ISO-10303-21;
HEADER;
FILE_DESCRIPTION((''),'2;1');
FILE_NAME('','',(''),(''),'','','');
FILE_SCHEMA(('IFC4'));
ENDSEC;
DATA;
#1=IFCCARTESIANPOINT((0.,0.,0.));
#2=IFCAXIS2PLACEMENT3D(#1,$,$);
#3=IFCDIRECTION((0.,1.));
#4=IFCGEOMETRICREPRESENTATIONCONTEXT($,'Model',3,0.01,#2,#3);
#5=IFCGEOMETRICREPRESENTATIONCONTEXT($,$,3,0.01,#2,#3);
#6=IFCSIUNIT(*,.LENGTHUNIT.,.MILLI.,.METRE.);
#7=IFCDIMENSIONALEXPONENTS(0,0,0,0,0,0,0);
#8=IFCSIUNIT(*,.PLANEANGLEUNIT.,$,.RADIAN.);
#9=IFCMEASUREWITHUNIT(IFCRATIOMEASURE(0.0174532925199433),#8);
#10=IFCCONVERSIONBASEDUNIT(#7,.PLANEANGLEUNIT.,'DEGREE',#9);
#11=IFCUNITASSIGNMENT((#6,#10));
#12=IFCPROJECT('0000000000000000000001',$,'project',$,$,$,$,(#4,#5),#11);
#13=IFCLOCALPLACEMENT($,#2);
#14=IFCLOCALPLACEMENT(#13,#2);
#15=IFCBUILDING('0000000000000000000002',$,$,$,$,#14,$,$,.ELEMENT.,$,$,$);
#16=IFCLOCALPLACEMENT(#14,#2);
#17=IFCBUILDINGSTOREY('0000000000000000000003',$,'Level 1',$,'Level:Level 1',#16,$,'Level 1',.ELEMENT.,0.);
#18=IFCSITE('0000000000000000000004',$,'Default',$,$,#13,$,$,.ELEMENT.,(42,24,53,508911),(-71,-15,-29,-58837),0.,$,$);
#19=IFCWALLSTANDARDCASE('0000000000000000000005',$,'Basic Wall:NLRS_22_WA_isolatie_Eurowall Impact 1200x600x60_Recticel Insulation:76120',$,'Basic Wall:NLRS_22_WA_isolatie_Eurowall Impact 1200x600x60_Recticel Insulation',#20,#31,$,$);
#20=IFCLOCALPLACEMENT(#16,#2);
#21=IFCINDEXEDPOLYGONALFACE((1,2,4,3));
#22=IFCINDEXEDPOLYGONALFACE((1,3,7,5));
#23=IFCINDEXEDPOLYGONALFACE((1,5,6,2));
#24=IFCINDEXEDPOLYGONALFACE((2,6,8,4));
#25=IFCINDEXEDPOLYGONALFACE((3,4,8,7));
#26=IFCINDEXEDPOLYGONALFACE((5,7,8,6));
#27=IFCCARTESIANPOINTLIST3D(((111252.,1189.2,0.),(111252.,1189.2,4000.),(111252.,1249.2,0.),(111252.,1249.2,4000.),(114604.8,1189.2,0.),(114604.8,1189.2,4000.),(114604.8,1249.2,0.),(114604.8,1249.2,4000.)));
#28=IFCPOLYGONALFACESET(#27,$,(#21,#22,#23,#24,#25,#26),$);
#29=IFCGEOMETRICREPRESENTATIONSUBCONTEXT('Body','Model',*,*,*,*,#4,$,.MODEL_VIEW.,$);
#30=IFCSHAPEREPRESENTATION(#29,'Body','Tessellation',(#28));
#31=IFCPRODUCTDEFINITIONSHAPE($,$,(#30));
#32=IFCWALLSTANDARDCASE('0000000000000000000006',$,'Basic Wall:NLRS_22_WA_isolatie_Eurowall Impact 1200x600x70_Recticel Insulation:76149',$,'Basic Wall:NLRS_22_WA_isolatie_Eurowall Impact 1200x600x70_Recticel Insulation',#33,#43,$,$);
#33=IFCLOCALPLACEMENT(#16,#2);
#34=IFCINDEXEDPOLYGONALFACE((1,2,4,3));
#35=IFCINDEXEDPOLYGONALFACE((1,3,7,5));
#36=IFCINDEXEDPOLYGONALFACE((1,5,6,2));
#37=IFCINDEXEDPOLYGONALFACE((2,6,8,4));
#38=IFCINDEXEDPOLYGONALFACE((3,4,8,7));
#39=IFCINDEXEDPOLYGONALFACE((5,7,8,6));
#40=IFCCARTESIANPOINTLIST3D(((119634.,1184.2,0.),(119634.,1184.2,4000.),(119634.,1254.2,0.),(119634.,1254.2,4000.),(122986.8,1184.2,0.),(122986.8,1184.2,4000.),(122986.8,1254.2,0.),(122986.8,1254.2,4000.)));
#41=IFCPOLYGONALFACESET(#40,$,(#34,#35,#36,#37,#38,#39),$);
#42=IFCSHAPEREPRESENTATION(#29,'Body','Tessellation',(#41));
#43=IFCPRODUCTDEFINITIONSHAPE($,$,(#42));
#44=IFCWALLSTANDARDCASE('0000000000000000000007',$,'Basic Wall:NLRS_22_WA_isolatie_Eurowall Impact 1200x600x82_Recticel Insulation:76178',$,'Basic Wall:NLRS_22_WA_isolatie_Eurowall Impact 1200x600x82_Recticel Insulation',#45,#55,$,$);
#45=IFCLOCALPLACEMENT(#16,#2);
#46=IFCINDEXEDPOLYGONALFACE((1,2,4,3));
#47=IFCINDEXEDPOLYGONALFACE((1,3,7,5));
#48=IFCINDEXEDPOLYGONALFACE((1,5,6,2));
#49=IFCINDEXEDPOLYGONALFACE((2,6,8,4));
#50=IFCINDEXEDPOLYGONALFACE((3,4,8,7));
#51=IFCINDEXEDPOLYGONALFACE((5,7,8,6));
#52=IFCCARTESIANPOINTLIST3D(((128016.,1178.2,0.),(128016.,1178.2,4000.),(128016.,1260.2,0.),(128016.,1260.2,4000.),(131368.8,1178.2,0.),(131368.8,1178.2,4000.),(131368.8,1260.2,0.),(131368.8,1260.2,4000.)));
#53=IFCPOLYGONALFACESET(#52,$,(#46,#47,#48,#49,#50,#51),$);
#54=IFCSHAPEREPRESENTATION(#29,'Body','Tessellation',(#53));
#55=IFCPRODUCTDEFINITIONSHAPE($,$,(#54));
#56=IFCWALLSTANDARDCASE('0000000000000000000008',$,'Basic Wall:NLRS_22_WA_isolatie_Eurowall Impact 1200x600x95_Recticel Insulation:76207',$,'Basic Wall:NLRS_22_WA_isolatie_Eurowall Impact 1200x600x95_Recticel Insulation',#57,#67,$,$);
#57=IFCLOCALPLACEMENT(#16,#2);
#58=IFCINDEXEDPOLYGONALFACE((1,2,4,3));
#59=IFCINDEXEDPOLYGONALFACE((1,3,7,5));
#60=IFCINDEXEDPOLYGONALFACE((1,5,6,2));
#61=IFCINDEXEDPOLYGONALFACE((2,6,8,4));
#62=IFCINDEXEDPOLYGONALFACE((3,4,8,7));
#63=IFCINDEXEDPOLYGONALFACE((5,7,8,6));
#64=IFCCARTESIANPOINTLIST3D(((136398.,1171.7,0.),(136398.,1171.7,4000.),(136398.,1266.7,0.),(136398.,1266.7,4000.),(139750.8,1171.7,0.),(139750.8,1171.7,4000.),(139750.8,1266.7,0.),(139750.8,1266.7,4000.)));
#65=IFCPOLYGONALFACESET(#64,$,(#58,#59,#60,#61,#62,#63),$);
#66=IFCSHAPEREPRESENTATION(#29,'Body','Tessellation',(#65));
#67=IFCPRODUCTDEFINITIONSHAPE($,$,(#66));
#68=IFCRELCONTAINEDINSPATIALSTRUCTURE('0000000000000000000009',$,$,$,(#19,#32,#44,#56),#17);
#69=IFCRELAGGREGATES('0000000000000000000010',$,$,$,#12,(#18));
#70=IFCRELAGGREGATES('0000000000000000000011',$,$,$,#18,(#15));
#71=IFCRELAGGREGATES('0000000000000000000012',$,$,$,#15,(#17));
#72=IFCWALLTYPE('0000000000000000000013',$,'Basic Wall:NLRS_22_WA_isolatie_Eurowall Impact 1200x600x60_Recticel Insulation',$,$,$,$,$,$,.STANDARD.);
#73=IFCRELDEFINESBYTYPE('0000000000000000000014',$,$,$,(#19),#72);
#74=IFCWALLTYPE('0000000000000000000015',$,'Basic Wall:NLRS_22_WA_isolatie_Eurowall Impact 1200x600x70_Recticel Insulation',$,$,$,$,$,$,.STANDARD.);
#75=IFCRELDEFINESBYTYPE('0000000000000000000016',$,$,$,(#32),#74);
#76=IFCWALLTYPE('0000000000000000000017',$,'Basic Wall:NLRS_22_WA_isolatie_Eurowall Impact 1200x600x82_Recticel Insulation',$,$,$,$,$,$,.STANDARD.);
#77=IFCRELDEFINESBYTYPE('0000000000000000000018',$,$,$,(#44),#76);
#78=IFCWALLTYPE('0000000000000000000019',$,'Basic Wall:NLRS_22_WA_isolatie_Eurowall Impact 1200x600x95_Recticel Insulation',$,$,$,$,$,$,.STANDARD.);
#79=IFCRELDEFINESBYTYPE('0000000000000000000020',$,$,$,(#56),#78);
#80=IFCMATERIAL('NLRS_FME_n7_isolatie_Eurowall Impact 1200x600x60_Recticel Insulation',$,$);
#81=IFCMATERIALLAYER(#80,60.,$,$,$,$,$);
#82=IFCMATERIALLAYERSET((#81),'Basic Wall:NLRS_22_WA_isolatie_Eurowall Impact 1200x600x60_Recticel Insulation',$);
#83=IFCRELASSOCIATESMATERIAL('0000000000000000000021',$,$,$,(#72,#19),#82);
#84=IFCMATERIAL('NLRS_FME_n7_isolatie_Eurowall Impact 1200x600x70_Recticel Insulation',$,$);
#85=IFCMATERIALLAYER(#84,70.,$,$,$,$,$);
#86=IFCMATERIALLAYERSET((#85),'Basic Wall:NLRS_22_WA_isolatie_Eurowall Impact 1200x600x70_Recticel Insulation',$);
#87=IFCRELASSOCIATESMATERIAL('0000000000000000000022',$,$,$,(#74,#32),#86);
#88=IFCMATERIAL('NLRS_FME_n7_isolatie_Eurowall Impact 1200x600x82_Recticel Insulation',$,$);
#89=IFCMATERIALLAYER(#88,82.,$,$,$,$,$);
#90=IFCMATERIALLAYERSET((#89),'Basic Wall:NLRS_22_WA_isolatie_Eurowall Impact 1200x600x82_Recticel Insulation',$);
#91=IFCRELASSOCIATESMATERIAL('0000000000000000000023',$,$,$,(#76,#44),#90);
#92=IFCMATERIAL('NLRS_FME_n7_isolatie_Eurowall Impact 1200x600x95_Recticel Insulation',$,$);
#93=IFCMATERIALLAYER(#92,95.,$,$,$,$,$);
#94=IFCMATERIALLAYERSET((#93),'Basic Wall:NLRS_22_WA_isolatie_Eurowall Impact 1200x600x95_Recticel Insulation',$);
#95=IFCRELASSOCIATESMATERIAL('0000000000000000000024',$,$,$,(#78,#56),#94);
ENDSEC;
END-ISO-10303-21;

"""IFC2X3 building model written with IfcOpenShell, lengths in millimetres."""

from ifc_helpers import new_model, entity, si_unit, converted_unit, direction, frame, frame_2d, origin, place, context, subcontext, project, spatial, rectangle, extrude, material, layer, layer_set, layer_usage, type_object, element, save


model = new_model("IFC2X3")

# Units and contexts
model_context = context("Model", 3, precision=0.01, world=origin(), true_north=direction((0.0, 1.0)))
context_of_model = context(None, 3, precision=0.01, world=origin(), true_north=direction((0.0, 1.0)))
body_context = subcontext(model_context, "Body", "Model", "MODEL_VIEW")
ifc_project = project(units=[si_unit("LENGTHUNIT", "METRE", prefix="MILLI"), converted_unit("PLANEANGLEUNIT", "DEGREE", entity("IfcRatioMeasure", 0.0174532925199433), si_unit("PLANEANGLEUNIT", "RADIAN"), dimensions=[0, 0, 0, 0, 0, 0, 0])], contexts=[model_context, context_of_model])

# Site, building, storey
site_placement = place(None, origin())
site = spatial("IfcSite", under=ifc_project, at=site_placement, Name="Default", CompositionType="ELEMENT", RefLatitude=(42, 24, 53, 508911), RefLongitude=(-71, -15, -29, -58837), RefElevation=0.0)
building_placement = place(site_placement, origin())
building = spatial("IfcBuilding", under=site, at=building_placement, CompositionType="ELEMENT")
storey_placement = place(building_placement, origin())
storey = spatial("IfcBuildingStorey", under=building, at=storey_placement, Name="Level 1", ObjectType="Level:Level 1", LongName="Level 1", CompositionType="ELEMENT", Elevation=0.0)

# Walls
ifc_material_1 = material(Name="NLRS_FME_n7_isolatie_Eurowall Impact 1200x600x60_Recticel Insulation")
ifc_layer_1 = layer(ifc_material_1, 60.0)
ifc_layer_set_1 = layer_set([ifc_layer_1], Name="Basic Wall:NLRS_22_WA_isolatie_Eurowall Impact 1200x600x60_Recticel Insulation")
ifc_layer_usage_1 = layer_usage(ifc_layer_set_1, "AXIS2", "NEGATIVE", 30.0)
wall_type_1 = type_object("IfcWallType", Name="Basic Wall:NLRS_22_WA_isolatie_Eurowall Impact 1200x600x60_Recticel Insulation", PredefinedType="STANDARD", material=ifc_layer_set_1)
wall_1_placement = place(storey_placement, frame((111252.0, 1219.2, 0.0)))
element("IfcWallStandardCase", 1, at=wall_1_placement, inside=storey, type_object=wall_type_1, material=ifc_layer_usage_1, Name="Basic Wall:NLRS_22_WA_isolatie_Eurowall Impact 1200x600x60_Recticel Insulation:76120", ObjectType="Basic Wall:NLRS_22_WA_isolatie_Eurowall Impact 1200x600x60_Recticel Insulation", context=body_context, shape_type="SweptSolid", body=[
    extrude(rectangle(XDim=3352.8, YDim=60.0, at=frame_2d((1676.4, 0.0), x_axis=(-1.0, 0.0))), origin(), (0.0, 0.0, 1.0), 4000.0),
])
ifc_material_2 = material(Name="NLRS_FME_n7_isolatie_Eurowall Impact 1200x600x70_Recticel Insulation")
ifc_layer_2 = layer(ifc_material_2, 70.0)
ifc_layer_set_2 = layer_set([ifc_layer_2], Name="Basic Wall:NLRS_22_WA_isolatie_Eurowall Impact 1200x600x70_Recticel Insulation")
ifc_layer_usage_2 = layer_usage(ifc_layer_set_2, "AXIS2", "NEGATIVE", 35.0)
wall_type_2 = type_object("IfcWallType", Name="Basic Wall:NLRS_22_WA_isolatie_Eurowall Impact 1200x600x70_Recticel Insulation", PredefinedType="STANDARD", material=ifc_layer_set_2)
wall_2_placement = place(storey_placement, frame((119634.0, 1219.2, 0.0)))
element("IfcWallStandardCase", 2, at=wall_2_placement, inside=storey, type_object=wall_type_2, material=ifc_layer_usage_2, Name="Basic Wall:NLRS_22_WA_isolatie_Eurowall Impact 1200x600x70_Recticel Insulation:76149", ObjectType="Basic Wall:NLRS_22_WA_isolatie_Eurowall Impact 1200x600x70_Recticel Insulation", context=body_context, shape_type="SweptSolid", body=[
    extrude(rectangle(XDim=3352.8, YDim=70.0, at=frame_2d((1676.4, 0.0), x_axis=(-1.0, 0.0))), origin(), (0.0, 0.0, 1.0), 4000.0),
])
ifc_material_3 = material(Name="NLRS_FME_n7_isolatie_Eurowall Impact 1200x600x82_Recticel Insulation")
ifc_layer_3 = layer(ifc_material_3, 82.0)
ifc_layer_set_3 = layer_set([ifc_layer_3], Name="Basic Wall:NLRS_22_WA_isolatie_Eurowall Impact 1200x600x82_Recticel Insulation")
ifc_layer_usage_3 = layer_usage(ifc_layer_set_3, "AXIS2", "NEGATIVE", 41.0)
wall_type_3 = type_object("IfcWallType", Name="Basic Wall:NLRS_22_WA_isolatie_Eurowall Impact 1200x600x82_Recticel Insulation", PredefinedType="STANDARD", material=ifc_layer_set_3)
wall_3_placement = place(storey_placement, frame((128016.0, 1219.2, 0.0)))
element("IfcWallStandardCase", 3, at=wall_3_placement, inside=storey, type_object=wall_type_3, material=ifc_layer_usage_3, Name="Basic Wall:NLRS_22_WA_isolatie_Eurowall Impact 1200x600x82_Recticel Insulation:76178", ObjectType="Basic Wall:NLRS_22_WA_isolatie_Eurowall Impact 1200x600x82_Recticel Insulation", context=body_context, shape_type="SweptSolid", body=[
    extrude(rectangle(XDim=3352.8, YDim=82.0, at=frame_2d((1676.4, 0.0), x_axis=(-1.0, 0.0))), origin(), (0.0, 0.0, 1.0), 4000.0),
])
ifc_material_4 = material(Name="NLRS_FME_n7_isolatie_Eurowall Impact 1200x600x95_Recticel Insulation")
ifc_layer_4 = layer(ifc_material_4, 95.0)
ifc_layer_set_4 = layer_set([ifc_layer_4], Name="Basic Wall:NLRS_22_WA_isolatie_Eurowall Impact 1200x600x95_Recticel Insulation")
ifc_layer_usage_4 = layer_usage(ifc_layer_set_4, "AXIS2", "NEGATIVE", 47.5)
wall_type_4 = type_object("IfcWallType", Name="Basic Wall:NLRS_22_WA_isolatie_Eurowall Impact 1200x600x95_Recticel Insulation", PredefinedType="STANDARD", material=ifc_layer_set_4)
wall_4_placement = place(storey_placement, frame((136398.0, 1219.2, 0.0)))
element("IfcWallStandardCase", 4, at=wall_4_placement, inside=storey, type_object=wall_type_4, material=ifc_layer_usage_4, Name="Basic Wall:NLRS_22_WA_isolatie_Eurowall Impact 1200x600x95_Recticel Insulation:76207", ObjectType="Basic Wall:NLRS_22_WA_isolatie_Eurowall Impact 1200x600x95_Recticel Insulation", context=body_context, shape_type="SweptSolid", body=[
    extrude(rectangle(XDim=3352.8, YDim=95.0, at=frame_2d((1676.4, 0.0), x_axis=(-1.0, 0.0))), origin(), (0.0, 0.0, 1.0), 4000.0),
])

save(model, "model.ifc")
